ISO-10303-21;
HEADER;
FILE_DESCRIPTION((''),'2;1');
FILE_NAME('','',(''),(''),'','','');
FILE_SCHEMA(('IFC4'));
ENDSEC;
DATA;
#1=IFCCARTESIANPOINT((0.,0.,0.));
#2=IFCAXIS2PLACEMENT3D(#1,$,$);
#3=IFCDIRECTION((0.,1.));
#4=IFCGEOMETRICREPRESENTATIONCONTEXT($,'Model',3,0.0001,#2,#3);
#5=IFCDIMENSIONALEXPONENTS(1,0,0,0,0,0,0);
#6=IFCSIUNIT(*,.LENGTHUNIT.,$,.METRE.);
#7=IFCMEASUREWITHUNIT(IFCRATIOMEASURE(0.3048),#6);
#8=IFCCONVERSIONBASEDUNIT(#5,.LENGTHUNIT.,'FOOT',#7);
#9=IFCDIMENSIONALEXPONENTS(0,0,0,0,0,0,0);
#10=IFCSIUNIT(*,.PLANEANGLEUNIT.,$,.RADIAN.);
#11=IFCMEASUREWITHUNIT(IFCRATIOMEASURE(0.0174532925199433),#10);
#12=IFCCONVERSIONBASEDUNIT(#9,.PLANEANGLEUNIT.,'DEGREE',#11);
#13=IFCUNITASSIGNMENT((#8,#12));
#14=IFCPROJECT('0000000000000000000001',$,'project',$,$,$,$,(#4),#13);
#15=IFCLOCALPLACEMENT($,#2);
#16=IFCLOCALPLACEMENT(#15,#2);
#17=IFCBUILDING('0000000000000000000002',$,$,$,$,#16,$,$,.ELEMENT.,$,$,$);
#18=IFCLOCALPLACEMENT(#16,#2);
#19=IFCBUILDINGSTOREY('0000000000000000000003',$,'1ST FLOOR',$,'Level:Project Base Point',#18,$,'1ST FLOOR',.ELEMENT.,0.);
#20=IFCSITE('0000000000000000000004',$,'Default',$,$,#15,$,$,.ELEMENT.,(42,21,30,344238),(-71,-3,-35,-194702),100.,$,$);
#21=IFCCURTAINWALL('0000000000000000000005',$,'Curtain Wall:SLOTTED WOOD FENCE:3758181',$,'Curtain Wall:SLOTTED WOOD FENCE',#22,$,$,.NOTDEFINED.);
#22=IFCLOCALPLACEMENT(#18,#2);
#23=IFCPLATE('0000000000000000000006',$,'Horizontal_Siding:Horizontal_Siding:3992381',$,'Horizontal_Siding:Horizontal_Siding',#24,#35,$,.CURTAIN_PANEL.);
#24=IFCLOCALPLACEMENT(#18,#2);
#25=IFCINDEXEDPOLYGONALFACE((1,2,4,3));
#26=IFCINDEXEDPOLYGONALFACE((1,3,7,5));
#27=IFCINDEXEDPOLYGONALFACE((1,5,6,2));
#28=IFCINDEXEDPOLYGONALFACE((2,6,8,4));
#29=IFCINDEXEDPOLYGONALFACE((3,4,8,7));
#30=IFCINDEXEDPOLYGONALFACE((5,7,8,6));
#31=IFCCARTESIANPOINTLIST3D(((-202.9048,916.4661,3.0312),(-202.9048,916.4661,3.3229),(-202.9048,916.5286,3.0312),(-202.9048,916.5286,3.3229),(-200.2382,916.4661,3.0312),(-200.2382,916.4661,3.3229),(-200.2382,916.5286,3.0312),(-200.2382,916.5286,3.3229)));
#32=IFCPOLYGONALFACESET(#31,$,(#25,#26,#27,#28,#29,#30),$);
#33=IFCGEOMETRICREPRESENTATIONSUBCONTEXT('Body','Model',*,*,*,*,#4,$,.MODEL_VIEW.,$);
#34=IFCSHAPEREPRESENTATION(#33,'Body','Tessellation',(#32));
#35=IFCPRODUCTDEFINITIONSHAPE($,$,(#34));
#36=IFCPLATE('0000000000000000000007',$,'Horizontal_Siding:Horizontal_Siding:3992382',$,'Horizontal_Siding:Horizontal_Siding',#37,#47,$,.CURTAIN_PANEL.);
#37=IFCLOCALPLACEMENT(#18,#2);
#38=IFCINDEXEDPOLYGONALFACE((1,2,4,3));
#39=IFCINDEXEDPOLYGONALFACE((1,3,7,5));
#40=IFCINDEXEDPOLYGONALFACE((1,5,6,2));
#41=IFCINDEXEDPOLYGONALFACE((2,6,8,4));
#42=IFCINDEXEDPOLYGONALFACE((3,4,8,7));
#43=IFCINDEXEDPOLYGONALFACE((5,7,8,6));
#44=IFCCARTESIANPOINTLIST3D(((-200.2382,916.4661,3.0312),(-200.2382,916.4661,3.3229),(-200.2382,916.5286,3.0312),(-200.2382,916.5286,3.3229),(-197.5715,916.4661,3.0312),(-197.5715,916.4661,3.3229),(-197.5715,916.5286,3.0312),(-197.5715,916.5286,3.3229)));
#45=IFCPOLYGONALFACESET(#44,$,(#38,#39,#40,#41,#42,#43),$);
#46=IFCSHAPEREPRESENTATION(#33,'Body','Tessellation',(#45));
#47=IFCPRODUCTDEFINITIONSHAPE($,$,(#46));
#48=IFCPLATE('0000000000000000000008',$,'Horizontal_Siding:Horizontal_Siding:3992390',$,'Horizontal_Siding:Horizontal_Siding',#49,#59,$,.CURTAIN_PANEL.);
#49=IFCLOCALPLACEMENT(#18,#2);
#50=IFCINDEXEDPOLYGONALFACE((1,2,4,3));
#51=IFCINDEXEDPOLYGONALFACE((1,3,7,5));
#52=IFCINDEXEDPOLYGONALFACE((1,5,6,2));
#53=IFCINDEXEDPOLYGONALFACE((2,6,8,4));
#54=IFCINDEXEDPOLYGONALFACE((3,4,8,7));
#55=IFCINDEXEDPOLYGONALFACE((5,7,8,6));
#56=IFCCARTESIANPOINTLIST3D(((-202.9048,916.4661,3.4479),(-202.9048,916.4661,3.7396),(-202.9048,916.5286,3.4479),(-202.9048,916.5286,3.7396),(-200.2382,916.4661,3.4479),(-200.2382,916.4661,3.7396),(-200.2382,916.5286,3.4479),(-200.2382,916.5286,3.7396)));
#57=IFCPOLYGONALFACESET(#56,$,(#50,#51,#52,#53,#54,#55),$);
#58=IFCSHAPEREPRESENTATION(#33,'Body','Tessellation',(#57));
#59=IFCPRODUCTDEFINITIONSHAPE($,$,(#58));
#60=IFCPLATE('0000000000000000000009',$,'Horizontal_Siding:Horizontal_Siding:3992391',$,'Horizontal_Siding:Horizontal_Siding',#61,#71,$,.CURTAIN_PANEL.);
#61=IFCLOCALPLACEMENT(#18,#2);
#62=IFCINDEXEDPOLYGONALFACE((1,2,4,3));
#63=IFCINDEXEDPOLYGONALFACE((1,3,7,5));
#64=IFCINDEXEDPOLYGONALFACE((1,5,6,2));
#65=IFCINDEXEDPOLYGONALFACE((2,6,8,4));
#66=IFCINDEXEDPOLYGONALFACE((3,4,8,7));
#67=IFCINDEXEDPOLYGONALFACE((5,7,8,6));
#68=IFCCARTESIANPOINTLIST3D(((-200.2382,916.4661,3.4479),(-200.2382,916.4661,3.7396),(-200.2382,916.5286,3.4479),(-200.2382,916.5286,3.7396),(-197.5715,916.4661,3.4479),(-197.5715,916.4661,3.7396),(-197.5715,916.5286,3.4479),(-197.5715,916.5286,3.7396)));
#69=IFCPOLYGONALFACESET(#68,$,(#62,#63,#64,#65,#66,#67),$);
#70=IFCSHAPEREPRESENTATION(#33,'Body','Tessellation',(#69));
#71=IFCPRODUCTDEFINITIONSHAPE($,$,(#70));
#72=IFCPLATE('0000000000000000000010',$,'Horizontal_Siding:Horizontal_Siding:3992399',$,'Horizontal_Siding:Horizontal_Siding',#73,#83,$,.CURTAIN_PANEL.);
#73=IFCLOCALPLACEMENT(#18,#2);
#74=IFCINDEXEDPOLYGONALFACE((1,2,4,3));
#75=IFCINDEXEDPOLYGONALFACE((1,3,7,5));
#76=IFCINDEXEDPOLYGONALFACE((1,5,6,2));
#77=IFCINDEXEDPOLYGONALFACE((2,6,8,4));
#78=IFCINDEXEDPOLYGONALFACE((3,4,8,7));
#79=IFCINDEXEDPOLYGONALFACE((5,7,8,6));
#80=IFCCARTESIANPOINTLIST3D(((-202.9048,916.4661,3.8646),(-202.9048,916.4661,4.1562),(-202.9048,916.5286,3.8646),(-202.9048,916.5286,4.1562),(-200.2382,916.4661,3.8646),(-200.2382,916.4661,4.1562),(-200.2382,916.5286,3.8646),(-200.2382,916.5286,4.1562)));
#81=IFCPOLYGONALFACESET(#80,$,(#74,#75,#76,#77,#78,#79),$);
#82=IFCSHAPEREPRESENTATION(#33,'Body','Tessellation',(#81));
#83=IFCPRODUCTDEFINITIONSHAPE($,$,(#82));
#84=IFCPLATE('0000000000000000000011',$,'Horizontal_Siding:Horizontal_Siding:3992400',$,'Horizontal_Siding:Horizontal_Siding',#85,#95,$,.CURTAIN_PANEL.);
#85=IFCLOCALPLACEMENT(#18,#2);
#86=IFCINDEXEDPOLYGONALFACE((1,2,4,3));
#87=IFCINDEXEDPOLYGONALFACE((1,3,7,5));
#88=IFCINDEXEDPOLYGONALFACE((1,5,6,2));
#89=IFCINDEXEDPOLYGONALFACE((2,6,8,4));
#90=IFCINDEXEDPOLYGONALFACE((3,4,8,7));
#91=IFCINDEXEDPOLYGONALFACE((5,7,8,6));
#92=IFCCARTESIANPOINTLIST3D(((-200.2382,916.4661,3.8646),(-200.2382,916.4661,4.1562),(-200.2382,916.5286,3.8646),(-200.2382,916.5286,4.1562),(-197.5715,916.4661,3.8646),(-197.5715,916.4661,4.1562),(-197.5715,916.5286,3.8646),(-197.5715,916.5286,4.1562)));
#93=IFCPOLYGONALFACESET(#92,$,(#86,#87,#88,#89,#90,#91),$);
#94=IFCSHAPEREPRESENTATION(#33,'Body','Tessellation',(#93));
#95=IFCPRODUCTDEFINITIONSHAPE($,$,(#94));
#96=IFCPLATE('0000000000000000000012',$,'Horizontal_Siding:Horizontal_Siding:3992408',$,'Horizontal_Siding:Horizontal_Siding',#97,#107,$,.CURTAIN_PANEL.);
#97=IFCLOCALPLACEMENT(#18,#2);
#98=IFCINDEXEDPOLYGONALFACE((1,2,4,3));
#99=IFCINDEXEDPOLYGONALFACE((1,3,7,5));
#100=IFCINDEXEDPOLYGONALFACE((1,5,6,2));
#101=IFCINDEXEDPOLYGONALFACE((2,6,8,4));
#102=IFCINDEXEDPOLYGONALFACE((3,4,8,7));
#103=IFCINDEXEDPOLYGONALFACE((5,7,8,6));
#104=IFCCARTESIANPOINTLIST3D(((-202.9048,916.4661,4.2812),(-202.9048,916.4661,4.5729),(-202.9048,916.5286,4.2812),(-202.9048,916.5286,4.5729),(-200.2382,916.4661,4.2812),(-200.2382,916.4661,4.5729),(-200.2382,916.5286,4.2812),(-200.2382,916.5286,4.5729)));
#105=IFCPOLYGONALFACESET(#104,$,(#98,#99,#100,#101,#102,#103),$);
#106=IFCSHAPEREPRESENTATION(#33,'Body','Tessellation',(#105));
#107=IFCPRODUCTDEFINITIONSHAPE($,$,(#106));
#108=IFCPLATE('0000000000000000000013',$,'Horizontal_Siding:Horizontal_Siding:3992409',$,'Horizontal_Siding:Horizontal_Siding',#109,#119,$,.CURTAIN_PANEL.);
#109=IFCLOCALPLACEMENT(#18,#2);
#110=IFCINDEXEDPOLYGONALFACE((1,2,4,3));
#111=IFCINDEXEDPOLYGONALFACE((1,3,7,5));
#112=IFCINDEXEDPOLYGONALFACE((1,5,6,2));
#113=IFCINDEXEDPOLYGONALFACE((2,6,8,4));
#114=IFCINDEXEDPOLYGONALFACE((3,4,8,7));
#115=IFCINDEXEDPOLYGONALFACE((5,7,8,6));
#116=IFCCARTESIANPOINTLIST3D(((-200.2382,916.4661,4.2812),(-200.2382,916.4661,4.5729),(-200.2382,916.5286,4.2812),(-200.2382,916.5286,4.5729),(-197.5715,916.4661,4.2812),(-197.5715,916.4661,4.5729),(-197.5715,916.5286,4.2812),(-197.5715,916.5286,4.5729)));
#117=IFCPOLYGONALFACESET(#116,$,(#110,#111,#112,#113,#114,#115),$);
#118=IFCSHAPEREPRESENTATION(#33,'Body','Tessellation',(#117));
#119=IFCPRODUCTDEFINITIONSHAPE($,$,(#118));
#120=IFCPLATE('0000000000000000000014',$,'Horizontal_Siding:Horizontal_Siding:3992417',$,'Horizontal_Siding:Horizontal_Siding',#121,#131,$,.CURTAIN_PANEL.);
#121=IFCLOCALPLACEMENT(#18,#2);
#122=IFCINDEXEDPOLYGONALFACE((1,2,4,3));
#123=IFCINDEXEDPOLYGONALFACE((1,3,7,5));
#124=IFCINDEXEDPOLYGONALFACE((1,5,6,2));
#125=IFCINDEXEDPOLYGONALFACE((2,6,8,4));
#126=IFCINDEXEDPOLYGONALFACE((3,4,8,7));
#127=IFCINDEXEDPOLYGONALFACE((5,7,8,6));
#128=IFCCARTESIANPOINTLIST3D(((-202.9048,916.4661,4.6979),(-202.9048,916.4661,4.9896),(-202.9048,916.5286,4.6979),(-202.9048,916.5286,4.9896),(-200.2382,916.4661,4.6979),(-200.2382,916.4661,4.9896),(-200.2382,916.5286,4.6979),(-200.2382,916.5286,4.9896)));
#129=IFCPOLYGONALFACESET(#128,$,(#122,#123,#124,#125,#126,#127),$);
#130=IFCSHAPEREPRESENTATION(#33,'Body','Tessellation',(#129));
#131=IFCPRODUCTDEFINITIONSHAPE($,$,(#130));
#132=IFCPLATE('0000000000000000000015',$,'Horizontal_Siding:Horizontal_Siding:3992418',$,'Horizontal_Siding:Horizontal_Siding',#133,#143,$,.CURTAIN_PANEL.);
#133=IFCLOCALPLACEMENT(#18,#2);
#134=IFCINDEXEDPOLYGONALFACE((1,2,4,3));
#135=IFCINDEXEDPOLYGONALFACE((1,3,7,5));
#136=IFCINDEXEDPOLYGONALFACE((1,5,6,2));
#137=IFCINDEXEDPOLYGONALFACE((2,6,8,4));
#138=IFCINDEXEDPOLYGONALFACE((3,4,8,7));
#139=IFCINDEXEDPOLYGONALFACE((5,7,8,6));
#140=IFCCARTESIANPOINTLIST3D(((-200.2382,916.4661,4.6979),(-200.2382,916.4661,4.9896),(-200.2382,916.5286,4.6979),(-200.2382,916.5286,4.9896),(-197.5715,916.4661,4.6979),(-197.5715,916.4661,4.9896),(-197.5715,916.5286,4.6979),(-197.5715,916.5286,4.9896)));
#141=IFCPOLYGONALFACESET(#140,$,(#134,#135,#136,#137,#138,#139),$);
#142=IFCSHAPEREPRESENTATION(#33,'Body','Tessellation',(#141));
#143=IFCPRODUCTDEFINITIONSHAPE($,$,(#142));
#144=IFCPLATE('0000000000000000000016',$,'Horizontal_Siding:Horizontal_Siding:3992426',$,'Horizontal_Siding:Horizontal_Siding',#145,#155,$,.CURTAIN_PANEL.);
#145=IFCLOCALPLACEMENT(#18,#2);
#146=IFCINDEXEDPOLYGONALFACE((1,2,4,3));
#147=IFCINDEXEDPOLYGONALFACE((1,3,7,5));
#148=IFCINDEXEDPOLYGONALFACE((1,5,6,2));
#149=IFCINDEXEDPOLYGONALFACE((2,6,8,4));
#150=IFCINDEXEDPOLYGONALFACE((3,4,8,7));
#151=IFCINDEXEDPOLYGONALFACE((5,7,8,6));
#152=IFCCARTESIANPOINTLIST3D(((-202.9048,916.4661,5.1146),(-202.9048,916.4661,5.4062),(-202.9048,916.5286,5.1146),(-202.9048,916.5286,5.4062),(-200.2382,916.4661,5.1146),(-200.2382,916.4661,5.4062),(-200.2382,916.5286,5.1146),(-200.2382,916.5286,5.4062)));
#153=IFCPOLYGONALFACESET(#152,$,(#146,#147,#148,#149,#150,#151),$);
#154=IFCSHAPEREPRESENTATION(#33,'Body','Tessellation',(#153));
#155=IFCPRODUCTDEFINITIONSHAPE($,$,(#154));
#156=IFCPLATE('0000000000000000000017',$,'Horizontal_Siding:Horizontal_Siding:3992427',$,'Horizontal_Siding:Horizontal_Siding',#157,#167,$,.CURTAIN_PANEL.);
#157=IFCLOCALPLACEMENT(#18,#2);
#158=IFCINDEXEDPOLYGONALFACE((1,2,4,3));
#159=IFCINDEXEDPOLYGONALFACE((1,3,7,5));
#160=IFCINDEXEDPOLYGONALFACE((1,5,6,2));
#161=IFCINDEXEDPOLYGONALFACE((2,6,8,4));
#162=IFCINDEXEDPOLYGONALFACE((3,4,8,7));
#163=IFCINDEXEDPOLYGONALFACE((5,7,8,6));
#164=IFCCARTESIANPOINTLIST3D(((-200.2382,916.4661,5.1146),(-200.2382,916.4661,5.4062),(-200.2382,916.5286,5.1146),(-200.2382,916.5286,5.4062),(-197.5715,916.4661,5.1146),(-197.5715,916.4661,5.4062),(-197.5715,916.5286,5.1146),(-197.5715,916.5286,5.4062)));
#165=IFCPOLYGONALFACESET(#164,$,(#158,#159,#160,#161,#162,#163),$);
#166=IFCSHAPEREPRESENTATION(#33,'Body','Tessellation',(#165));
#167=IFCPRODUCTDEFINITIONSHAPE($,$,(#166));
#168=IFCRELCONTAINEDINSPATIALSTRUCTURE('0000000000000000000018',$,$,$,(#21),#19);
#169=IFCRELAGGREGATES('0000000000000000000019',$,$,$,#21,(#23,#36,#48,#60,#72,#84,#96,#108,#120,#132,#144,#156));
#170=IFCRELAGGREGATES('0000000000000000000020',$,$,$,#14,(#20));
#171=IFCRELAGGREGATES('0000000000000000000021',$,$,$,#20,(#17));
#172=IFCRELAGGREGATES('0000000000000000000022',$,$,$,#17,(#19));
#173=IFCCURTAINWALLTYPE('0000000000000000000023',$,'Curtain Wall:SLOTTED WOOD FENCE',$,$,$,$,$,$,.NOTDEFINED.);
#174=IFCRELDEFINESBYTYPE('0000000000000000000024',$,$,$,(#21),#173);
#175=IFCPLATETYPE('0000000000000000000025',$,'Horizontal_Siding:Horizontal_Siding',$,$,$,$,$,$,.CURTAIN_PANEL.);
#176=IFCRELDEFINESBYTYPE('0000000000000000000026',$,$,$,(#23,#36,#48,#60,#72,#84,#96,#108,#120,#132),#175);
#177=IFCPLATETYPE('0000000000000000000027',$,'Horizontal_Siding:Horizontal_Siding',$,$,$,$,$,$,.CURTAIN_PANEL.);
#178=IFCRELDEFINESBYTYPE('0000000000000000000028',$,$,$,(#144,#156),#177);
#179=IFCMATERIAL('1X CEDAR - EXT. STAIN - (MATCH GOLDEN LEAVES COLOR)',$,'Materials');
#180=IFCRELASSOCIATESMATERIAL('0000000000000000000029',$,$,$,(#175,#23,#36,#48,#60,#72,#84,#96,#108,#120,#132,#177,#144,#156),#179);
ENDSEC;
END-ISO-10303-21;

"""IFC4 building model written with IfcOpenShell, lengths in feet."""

from ifc_helpers import new_model, entity, si_unit, converted_unit, direction, frame, origin, origin_2d_with_axis, place, context, subcontext, project, spatial, rectangle, extrude, source, transform, mapped, material, type_object, type_shapes, element, aggregate, save


model = new_model("IFC4")

# Units and contexts
model_context = context("Model", 3, precision=0.0001, world=origin(), true_north=direction((0.0, 1.0)))
body_context = subcontext(model_context, "Body", "Model", "MODEL_VIEW")
ifc_project = project(units=[converted_unit("LENGTHUNIT", "FOOT", entity("IfcRatioMeasure", 0.3048), si_unit("LENGTHUNIT", "METRE"), dimensions=[1, 0, 0, 0, 0, 0, 0]), converted_unit("PLANEANGLEUNIT", "DEGREE", entity("IfcRatioMeasure", 0.0174532925199433), si_unit("PLANEANGLEUNIT", "RADIAN"), dimensions=[0, 0, 0, 0, 0, 0, 0])], contexts=[model_context])

# Site, building, storey
site_placement = place(None, origin())
site = spatial("IfcSite", under=ifc_project, at=site_placement, Name="Default", CompositionType="ELEMENT", RefLatitude=(42, 21, 30, 344238), RefLongitude=(-71, -3, -35, -194702), RefElevation=100.0)
building_placement = place(site_placement, origin())
building = spatial("IfcBuilding", under=site, at=building_placement, CompositionType="ELEMENT")
storey_placement = place(building_placement, origin())
storey = spatial("IfcBuildingStorey", under=building, at=storey_placement, Name="1ST FLOOR", ObjectType="Level:Project Base Point", LongName="1ST FLOOR", CompositionType="ELEMENT", Elevation=0.0)

# Curtain wall
curtain_wall_type = type_object("IfcCurtainWallType", Name="Curtain Wall:SLOTTED WOOD FENCE", PredefinedType="NOTDEFINED")
curtain_wall_1_placement = place(storey_placement, origin())
curtain_wall_1 = element("IfcCurtainWall", 1, at=curtain_wall_1_placement, inside=storey, type_object=curtain_wall_type, Name="Curtain Wall:SLOTTED WOOD FENCE:3758181", ObjectType="Curtain Wall:SLOTTED WOOD FENCE", PredefinedType="NOTDEFINED")

# Plates
ifc_material_1 = material(Name="1X CEDAR - EXT. STAIN - (MATCH GOLDEN LEAVES COLOR)", Category="Materials")
plate_type_1 = type_object("IfcPlateType", Name="Horizontal_Siding:Horizontal_Siding", PredefinedType="CURTAIN_PANEL", material=ifc_material_1)
shared_shape_1 = source(origin(), body_context, "Body", "SweptSolid", [
    extrude(rectangle(XDim=2.6667, YDim=0.0625, at=origin_2d_with_axis()), frame((1.3333, 0.0312, 0.0), z_axis=(0.0, 0.0, 1.0), x_axis=(-1.0, 0.0, 0.0)), (0.0, 0.0, 1.0), 0.2917),
])
type_shapes(plate_type_1, [shared_shape_1])
plate_1_placement = place(curtain_wall_1_placement, frame((-202.9048, 916.4661, 3.0312)))
plate_1 = element("IfcPlate", 2, at=plate_1_placement, type_object=plate_type_1, material=ifc_material_1, Name="Horizontal_Siding:Horizontal_Siding:3992381", ObjectType="Horizontal_Siding:Horizontal_Siding", PredefinedType="CURTAIN_PANEL", context=body_context, shape_type="MappedRepresentation", body=[
    mapped(shared_shape_1, transform((0.0, 0.0, 0.0), scale=1.0)),
])
plate_2_placement = place(curtain_wall_1_placement, frame((-200.2382, 916.4661, 3.0312)))
plate_2 = element("IfcPlate", 3, at=plate_2_placement, type_object=plate_type_1, material=ifc_material_1, Name="Horizontal_Siding:Horizontal_Siding:3992382", ObjectType="Horizontal_Siding:Horizontal_Siding", PredefinedType="CURTAIN_PANEL", context=body_context, shape_type="MappedRepresentation", body=[
    mapped(shared_shape_1, transform((0.0, 0.0, 0.0), scale=1.0)),
])
plate_3_placement = place(curtain_wall_1_placement, frame((-202.9048, 916.4661, 3.4479)))
plate_3 = element("IfcPlate", 4, at=plate_3_placement, type_object=plate_type_1, material=ifc_material_1, Name="Horizontal_Siding:Horizontal_Siding:3992390", ObjectType="Horizontal_Siding:Horizontal_Siding", PredefinedType="CURTAIN_PANEL", context=body_context, shape_type="MappedRepresentation", body=[
    mapped(shared_shape_1, transform((0.0, 0.0, 0.0), scale=1.0)),
])
plate_4_placement = place(curtain_wall_1_placement, frame((-200.2382, 916.4661, 3.4479)))
plate_4 = element("IfcPlate", 5, at=plate_4_placement, type_object=plate_type_1, material=ifc_material_1, Name="Horizontal_Siding:Horizontal_Siding:3992391", ObjectType="Horizontal_Siding:Horizontal_Siding", PredefinedType="CURTAIN_PANEL", context=body_context, shape_type="MappedRepresentation", body=[
    mapped(shared_shape_1, transform((0.0, 0.0, 0.0), scale=1.0)),
])
plate_5_placement = place(curtain_wall_1_placement, frame((-202.9048, 916.4661, 3.8646)))
plate_5 = element("IfcPlate", 6, at=plate_5_placement, type_object=plate_type_1, material=ifc_material_1, Name="Horizontal_Siding:Horizontal_Siding:3992399", ObjectType="Horizontal_Siding:Horizontal_Siding", PredefinedType="CURTAIN_PANEL", context=body_context, shape_type="MappedRepresentation", body=[
    mapped(shared_shape_1, transform((0.0, 0.0, 0.0), scale=1.0)),
])
plate_6_placement = place(curtain_wall_1_placement, frame((-200.2382, 916.4661, 3.8646)))
plate_6 = element("IfcPlate", 7, at=plate_6_placement, type_object=plate_type_1, material=ifc_material_1, Name="Horizontal_Siding:Horizontal_Siding:3992400", ObjectType="Horizontal_Siding:Horizontal_Siding", PredefinedType="CURTAIN_PANEL", context=body_context, shape_type="MappedRepresentation", body=[
    mapped(shared_shape_1, transform((0.0, 0.0, 0.0), scale=1.0)),
])
plate_7_placement = place(curtain_wall_1_placement, frame((-202.9048, 916.4661, 4.2812)))
plate_7 = element("IfcPlate", 8, at=plate_7_placement, type_object=plate_type_1, material=ifc_material_1, Name="Horizontal_Siding:Horizontal_Siding:3992408", ObjectType="Horizontal_Siding:Horizontal_Siding", PredefinedType="CURTAIN_PANEL", context=body_context, shape_type="MappedRepresentation", body=[
    mapped(shared_shape_1, transform((0.0, 0.0, 0.0), scale=1.0)),
])
plate_8_placement = place(curtain_wall_1_placement, frame((-200.2382, 916.4661, 4.2812)))
plate_8 = element("IfcPlate", 9, at=plate_8_placement, type_object=plate_type_1, material=ifc_material_1, Name="Horizontal_Siding:Horizontal_Siding:3992409", ObjectType="Horizontal_Siding:Horizontal_Siding", PredefinedType="CURTAIN_PANEL", context=body_context, shape_type="MappedRepresentation", body=[
    mapped(shared_shape_1, transform((0.0, 0.0, 0.0), scale=1.0)),
])
plate_9_placement = place(curtain_wall_1_placement, frame((-202.9048, 916.4661, 4.6979)))
plate_9 = element("IfcPlate", 10, at=plate_9_placement, type_object=plate_type_1, material=ifc_material_1, Name="Horizontal_Siding:Horizontal_Siding:3992417", ObjectType="Horizontal_Siding:Horizontal_Siding", PredefinedType="CURTAIN_PANEL", context=body_context, shape_type="MappedRepresentation", body=[
    mapped(shared_shape_1, transform((0.0, 0.0, 0.0), scale=1.0)),
])
plate_10_placement = place(curtain_wall_1_placement, frame((-200.2382, 916.4661, 4.6979)))
plate_10 = element("IfcPlate", 11, at=plate_10_placement, type_object=plate_type_1, material=ifc_material_1, Name="Horizontal_Siding:Horizontal_Siding:3992418", ObjectType="Horizontal_Siding:Horizontal_Siding", PredefinedType="CURTAIN_PANEL", context=body_context, shape_type="MappedRepresentation", body=[
    mapped(shared_shape_1, transform((0.0, 0.0, 0.0), scale=1.0)),
])
plate_type_2 = type_object("IfcPlateType", Name="Horizontal_Siding:Horizontal_Siding", PredefinedType="CURTAIN_PANEL", material=ifc_material_1)
shared_shape_2 = source(origin(), body_context, "Body", "SweptSolid", [
    extrude(rectangle(XDim=2.6667, YDim=0.0625, at=origin_2d_with_axis()), frame((1.3333, 0.0312, 0.0), z_axis=(0.0, 0.0, 1.0), x_axis=(-1.0, 0.0, 0.0)), (0.0, 0.0, 1.0), 0.2917),
])
type_shapes(plate_type_2, [shared_shape_2])
plate_11_placement = place(curtain_wall_1_placement, frame((-202.9048, 916.4661, 5.1146)))
plate_11 = element("IfcPlate", 12, at=plate_11_placement, type_object=plate_type_2, material=ifc_material_1, Name="Horizontal_Siding:Horizontal_Siding:3992426", ObjectType="Horizontal_Siding:Horizontal_Siding", PredefinedType="CURTAIN_PANEL", context=body_context, shape_type="MappedRepresentation", body=[
    mapped(shared_shape_2, transform((0.0, 0.0, 0.0), scale=1.0)),
])
plate_12_placement = place(curtain_wall_1_placement, frame((-200.2382, 916.4661, 5.1146)))
plate_12 = element("IfcPlate", 13, at=plate_12_placement, type_object=plate_type_2, material=ifc_material_1, Name="Horizontal_Siding:Horizontal_Siding:3992427", ObjectType="Horizontal_Siding:Horizontal_Siding", PredefinedType="CURTAIN_PANEL", context=body_context, shape_type="MappedRepresentation", body=[
    mapped(shared_shape_2, transform((0.0, 0.0, 0.0), scale=1.0)),
])
aggregate(curtain_wall_1, [plate_1, plate_2, plate_3, plate_4, plate_5, plate_6, plate_7, plate_8, plate_9, plate_10, plate_11, plate_12])

save(model, "model.ifc")
